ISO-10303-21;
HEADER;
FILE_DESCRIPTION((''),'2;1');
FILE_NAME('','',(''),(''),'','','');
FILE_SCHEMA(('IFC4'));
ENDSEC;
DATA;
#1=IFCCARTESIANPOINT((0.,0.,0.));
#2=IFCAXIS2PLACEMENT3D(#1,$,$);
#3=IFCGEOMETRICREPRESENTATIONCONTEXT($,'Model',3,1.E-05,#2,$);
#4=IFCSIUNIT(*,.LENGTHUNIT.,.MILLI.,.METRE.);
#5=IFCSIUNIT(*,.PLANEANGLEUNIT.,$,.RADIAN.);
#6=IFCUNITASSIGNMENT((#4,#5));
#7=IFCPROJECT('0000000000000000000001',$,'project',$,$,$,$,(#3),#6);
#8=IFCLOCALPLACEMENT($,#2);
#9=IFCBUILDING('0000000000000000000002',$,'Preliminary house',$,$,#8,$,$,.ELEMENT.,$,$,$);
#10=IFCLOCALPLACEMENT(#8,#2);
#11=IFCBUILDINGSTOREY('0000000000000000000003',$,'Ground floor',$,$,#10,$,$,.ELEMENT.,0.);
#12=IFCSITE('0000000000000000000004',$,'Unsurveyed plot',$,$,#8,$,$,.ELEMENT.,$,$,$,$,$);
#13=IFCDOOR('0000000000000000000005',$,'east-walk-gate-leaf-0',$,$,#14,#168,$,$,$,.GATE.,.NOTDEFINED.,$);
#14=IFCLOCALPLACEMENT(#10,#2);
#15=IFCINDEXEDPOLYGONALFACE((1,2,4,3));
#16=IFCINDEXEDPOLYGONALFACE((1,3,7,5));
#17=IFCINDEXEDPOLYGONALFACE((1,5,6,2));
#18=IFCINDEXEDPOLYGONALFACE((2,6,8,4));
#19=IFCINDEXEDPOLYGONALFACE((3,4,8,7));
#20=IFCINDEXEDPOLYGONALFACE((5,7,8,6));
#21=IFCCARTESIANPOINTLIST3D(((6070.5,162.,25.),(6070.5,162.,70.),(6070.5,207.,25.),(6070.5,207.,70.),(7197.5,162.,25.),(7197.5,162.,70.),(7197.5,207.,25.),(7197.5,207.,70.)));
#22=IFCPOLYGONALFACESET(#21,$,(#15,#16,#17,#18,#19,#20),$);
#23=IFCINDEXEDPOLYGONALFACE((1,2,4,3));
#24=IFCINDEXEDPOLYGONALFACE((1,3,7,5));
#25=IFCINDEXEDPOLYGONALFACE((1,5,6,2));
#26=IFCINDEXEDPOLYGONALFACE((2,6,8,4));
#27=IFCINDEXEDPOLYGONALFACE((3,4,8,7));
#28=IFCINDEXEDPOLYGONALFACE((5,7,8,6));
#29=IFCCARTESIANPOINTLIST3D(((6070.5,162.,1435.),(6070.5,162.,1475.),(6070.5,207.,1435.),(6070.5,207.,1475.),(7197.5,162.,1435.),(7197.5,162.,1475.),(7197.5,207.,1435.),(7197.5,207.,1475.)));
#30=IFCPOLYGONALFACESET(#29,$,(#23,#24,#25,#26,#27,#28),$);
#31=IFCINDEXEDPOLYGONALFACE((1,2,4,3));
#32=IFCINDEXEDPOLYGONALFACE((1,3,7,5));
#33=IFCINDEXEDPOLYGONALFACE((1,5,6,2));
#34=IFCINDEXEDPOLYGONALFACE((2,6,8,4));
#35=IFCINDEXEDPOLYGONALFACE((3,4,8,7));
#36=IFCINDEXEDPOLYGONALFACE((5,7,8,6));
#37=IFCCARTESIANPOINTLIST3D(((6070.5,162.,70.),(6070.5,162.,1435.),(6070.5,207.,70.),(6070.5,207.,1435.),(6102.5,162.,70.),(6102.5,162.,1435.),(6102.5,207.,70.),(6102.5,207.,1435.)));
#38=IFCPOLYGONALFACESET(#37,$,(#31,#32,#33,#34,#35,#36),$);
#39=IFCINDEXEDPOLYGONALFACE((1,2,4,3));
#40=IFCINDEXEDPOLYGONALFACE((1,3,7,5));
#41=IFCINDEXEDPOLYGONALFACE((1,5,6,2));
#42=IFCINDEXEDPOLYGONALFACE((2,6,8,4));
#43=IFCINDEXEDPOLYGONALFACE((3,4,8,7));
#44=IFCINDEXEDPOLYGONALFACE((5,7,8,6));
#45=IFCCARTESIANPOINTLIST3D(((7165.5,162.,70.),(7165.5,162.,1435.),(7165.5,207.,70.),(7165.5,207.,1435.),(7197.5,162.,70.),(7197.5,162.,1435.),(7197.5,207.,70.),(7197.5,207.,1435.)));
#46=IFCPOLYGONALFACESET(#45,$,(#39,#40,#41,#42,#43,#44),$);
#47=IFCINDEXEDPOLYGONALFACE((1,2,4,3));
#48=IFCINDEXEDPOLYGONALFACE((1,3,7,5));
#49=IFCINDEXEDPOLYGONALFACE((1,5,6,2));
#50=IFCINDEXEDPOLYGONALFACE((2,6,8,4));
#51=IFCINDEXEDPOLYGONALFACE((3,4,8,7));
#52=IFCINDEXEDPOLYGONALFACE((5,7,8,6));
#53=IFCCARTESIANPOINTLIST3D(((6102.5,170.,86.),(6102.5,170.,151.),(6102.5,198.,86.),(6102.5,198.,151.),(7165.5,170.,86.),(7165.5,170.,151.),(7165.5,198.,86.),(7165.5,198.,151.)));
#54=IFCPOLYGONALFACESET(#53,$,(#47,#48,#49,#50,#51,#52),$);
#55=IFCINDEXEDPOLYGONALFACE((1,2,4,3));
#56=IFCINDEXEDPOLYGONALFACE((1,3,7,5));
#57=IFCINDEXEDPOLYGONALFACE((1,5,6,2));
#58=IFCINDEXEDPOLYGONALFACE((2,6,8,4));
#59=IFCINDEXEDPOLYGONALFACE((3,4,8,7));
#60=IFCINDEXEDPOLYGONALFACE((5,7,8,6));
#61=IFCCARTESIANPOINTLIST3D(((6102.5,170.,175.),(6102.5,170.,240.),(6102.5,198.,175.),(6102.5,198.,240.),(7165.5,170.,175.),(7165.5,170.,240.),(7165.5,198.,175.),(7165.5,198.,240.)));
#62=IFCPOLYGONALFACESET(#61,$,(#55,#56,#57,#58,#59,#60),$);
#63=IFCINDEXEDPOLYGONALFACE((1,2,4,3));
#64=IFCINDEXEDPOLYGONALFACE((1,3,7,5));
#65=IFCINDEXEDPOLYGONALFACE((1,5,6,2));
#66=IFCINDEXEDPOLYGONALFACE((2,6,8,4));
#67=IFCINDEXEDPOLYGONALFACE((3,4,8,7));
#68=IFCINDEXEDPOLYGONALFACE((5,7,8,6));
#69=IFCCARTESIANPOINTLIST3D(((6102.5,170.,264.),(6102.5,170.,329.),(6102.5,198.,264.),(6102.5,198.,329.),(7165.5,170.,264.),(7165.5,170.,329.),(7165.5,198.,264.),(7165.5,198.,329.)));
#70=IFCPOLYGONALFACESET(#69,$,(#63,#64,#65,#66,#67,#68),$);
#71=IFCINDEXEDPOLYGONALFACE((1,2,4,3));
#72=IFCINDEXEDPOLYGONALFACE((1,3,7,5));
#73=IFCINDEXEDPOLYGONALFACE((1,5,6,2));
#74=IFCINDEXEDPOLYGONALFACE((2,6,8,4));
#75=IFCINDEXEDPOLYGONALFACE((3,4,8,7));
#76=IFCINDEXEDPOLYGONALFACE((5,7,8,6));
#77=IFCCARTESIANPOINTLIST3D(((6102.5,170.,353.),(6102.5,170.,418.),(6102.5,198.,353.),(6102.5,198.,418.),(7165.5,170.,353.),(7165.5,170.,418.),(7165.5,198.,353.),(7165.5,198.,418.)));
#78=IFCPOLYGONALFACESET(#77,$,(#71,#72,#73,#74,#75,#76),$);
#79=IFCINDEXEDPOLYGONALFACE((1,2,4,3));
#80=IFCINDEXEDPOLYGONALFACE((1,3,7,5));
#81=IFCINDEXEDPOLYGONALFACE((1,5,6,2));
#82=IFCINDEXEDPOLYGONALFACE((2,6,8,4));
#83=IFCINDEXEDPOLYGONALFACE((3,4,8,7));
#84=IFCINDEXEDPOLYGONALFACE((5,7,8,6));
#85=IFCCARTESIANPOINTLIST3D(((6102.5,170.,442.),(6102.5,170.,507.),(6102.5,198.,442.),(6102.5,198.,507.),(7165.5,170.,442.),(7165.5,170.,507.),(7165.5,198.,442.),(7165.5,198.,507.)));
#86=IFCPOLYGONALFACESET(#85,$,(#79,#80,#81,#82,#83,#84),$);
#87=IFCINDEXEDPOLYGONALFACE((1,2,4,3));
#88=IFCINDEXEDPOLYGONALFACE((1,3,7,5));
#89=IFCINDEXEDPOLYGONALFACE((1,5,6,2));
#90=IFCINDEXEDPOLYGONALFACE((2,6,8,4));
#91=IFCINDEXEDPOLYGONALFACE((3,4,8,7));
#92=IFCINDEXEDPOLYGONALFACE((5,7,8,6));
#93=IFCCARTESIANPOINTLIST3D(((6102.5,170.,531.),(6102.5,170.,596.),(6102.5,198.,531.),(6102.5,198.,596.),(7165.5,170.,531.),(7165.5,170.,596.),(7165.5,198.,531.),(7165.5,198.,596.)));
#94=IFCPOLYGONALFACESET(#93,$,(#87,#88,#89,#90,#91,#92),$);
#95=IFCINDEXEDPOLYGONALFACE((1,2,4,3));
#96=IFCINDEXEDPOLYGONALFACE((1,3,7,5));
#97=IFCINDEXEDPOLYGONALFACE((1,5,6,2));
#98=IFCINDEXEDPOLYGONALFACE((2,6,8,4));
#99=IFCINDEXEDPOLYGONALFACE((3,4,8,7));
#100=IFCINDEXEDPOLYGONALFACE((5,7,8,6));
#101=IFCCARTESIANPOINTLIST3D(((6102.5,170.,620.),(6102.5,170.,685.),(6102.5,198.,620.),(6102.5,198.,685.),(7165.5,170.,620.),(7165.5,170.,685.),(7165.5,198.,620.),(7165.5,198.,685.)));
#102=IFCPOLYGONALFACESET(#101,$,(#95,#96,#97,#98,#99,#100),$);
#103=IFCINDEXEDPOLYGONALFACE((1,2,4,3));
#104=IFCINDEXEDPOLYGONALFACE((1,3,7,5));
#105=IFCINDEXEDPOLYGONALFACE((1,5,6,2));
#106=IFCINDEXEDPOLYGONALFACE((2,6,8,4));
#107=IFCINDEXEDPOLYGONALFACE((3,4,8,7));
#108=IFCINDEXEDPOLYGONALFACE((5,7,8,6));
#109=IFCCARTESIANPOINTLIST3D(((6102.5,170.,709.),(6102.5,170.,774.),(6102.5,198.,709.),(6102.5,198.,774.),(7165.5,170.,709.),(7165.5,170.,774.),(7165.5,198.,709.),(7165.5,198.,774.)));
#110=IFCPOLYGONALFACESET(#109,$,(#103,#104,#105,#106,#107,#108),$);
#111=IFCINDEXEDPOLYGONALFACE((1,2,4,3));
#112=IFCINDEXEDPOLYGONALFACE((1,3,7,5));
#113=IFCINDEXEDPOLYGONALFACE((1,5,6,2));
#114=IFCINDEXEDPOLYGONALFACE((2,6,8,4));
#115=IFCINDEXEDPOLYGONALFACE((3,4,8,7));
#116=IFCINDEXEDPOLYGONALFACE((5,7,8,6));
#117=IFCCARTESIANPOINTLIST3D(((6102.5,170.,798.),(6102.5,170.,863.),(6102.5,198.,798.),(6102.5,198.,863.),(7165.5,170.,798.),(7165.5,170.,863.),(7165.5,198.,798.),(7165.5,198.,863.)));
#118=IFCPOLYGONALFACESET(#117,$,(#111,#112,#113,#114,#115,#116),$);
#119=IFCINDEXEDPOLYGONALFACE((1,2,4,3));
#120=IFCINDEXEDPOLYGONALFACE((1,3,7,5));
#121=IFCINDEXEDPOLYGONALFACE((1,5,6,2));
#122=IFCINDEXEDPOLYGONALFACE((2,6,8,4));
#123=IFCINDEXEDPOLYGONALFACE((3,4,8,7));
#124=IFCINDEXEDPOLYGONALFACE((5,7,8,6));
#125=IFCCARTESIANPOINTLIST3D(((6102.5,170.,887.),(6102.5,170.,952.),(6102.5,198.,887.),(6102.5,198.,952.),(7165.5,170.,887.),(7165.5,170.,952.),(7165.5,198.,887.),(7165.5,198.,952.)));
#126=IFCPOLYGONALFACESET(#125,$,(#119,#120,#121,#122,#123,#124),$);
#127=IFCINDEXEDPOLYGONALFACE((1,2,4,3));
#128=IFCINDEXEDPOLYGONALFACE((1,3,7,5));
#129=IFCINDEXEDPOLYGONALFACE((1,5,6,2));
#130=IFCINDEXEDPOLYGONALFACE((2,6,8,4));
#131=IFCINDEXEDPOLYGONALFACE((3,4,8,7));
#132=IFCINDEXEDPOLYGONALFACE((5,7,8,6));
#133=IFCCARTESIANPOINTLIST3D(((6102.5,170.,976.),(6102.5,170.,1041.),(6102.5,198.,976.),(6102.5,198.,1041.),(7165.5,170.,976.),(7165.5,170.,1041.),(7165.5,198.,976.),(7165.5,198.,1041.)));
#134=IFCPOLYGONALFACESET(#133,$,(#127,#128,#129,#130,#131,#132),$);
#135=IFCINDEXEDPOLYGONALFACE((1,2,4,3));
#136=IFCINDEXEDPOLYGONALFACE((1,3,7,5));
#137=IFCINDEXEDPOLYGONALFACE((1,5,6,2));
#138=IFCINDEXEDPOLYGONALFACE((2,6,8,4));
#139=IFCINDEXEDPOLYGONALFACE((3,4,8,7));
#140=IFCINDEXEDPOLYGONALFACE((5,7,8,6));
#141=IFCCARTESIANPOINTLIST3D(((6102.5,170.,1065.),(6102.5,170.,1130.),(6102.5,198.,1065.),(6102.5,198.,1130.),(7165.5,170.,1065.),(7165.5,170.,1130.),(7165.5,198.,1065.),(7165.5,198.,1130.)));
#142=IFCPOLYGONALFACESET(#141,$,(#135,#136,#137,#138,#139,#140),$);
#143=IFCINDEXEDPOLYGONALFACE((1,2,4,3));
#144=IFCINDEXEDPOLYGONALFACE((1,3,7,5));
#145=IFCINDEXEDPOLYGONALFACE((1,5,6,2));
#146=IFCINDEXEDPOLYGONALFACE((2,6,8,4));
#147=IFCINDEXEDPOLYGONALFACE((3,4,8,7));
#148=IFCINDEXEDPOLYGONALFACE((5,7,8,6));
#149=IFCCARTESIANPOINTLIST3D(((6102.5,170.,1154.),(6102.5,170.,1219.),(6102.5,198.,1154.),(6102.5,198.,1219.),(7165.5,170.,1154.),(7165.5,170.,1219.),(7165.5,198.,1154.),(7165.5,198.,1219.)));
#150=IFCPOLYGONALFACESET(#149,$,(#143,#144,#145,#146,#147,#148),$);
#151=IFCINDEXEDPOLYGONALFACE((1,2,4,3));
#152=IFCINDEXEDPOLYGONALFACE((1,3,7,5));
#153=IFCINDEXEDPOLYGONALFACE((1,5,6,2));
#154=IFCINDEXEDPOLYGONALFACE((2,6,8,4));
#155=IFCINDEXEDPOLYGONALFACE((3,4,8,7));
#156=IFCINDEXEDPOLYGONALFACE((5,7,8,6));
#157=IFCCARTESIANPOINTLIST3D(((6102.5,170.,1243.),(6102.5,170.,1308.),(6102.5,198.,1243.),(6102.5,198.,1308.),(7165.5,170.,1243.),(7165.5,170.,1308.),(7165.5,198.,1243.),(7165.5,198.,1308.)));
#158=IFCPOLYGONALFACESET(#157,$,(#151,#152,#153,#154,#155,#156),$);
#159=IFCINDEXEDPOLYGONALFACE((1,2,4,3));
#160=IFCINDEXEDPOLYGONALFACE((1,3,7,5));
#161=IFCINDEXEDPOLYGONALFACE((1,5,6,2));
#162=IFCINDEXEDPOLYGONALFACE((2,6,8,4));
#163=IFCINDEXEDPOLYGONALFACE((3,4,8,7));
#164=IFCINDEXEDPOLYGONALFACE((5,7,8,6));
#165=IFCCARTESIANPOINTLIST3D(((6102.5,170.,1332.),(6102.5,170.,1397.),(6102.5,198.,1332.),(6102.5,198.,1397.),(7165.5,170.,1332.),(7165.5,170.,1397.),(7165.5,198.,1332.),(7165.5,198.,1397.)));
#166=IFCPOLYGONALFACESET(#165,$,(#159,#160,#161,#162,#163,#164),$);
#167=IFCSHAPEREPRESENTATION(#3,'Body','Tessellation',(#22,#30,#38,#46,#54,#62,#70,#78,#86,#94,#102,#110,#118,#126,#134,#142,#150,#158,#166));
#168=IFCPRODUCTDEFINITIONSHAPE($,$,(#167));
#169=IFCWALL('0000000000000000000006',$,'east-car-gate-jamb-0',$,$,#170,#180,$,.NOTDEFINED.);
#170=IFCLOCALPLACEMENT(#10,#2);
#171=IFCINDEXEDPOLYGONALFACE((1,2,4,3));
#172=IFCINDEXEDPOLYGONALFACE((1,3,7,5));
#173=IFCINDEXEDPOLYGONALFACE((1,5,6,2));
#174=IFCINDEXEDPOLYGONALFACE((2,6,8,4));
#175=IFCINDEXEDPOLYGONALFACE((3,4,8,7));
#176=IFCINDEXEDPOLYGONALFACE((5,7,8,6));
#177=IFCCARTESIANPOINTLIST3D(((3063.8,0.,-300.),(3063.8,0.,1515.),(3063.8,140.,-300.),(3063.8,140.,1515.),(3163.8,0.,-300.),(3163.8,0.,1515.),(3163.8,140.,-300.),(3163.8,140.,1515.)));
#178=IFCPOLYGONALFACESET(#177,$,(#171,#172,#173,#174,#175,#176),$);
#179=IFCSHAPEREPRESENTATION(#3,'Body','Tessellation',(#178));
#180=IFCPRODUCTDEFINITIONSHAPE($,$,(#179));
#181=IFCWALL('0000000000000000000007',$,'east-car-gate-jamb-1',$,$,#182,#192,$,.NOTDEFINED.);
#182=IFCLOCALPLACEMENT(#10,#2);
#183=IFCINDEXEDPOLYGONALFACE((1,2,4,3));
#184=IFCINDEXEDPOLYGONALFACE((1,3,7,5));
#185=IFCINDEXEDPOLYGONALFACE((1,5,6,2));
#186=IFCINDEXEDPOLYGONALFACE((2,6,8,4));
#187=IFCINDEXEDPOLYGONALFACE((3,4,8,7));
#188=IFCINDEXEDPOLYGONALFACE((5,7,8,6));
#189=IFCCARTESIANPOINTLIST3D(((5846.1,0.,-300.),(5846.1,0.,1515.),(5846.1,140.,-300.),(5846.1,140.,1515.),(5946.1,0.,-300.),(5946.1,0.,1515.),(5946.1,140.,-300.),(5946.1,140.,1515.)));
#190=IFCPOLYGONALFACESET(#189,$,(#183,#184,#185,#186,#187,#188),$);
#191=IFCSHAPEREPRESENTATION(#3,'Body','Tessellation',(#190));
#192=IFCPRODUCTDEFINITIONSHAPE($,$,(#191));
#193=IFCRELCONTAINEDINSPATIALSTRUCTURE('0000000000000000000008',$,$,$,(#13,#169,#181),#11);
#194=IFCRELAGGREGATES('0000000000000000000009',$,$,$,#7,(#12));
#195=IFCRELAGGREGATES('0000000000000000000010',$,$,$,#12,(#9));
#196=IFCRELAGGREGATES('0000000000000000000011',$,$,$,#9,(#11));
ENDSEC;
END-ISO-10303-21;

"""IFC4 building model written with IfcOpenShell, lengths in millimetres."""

from ifc_helpers import new_model, si_unit, frame, origin, place, context, project, spatial, polyline, outline, extrude, element, save


model = new_model("IFC4")

# Units and contexts
model_context = context("Model", 3, precision=1e-05, world=origin())
ifc_project = project(units=[si_unit("LENGTHUNIT", "METRE", prefix="MILLI"), si_unit("PLANEANGLEUNIT", "RADIAN")], contexts=[model_context])

# Site, building, storey
placement_1 = place(None, origin())
site = spatial("IfcSite", under=ifc_project, at=placement_1, Name="Unsurveyed plot", CompositionType="ELEMENT")
building = spatial("IfcBuilding", under=site, at=placement_1, Name="Preliminary house", CompositionType="ELEMENT")
placement_2 = place(placement_1, origin())
storey = spatial("IfcBuildingStorey", under=building, at=placement_2, Name="Ground floor", CompositionType="ELEMENT", Elevation=0.0)

# Door
element("IfcDoor", 1, at=placement_2, inside=storey, Name="east-walk-gate-leaf-0", OperationType="NOTDEFINED", PredefinedType="GATE", context=model_context, shape_type="SweptSolid", body=[
    extrude(outline(polyline([(7197.5, 162.0), (7197.5, 207.0), (6070.5, 207.0), (6070.5, 162.0), (7197.5, 162.0)])), frame((0.0, 0.0, 25.0)), (0.0, 0.0, 1.0), 45.0),
    extrude(outline(polyline([(7197.5, 162.0), (7197.5, 207.0), (6070.5, 207.0), (6070.5, 162.0), (7197.5, 162.0)])), frame((0.0, 0.0, 1435.0)), (0.0, 0.0, 1.0), 40.0),
    extrude(outline(polyline([(6102.5, 162.0), (6102.5, 207.0), (6070.5, 207.0), (6070.5, 162.0), (6102.5, 162.0)])), frame((0.0, 0.0, 70.0)), (0.0, 0.0, 1.0), 1365.0),
    extrude(outline(polyline([(7197.5, 162.0), (7197.5, 207.0), (7165.5, 207.0), (7165.5, 162.0), (7197.5, 162.0)])), frame((0.0, 0.0, 70.0)), (0.0, 0.0, 1.0), 1365.0),
    extrude(outline(polyline([(7165.5, 170.0), (7165.5, 198.0), (6102.5, 198.0), (6102.5, 170.0), (7165.5, 170.0)])), frame((0.0, 0.0, 86.0)), (0.0, 0.0, 1.0), 65.0),
    extrude(outline(polyline([(7165.5, 170.0), (7165.5, 198.0), (6102.5, 198.0), (6102.5, 170.0), (7165.5, 170.0)])), frame((0.0, 0.0, 175.0)), (0.0, 0.0, 1.0), 65.0),
    extrude(outline(polyline([(7165.5, 170.0), (7165.5, 198.0), (6102.5, 198.0), (6102.5, 170.0), (7165.5, 170.0)])), frame((0.0, 0.0, 264.0)), (0.0, 0.0, 1.0), 65.0),
    extrude(outline(polyline([(7165.5, 170.0), (7165.5, 198.0), (6102.5, 198.0), (6102.5, 170.0), (7165.5, 170.0)])), frame((0.0, 0.0, 353.0)), (0.0, 0.0, 1.0), 65.0),
    extrude(outline(polyline([(7165.5, 170.0), (7165.5, 198.0), (6102.5, 198.0), (6102.5, 170.0), (7165.5, 170.0)])), frame((0.0, 0.0, 442.0)), (0.0, 0.0, 1.0), 65.0),
    extrude(outline(polyline([(7165.5, 170.0), (7165.5, 198.0), (6102.5, 198.0), (6102.5, 170.0), (7165.5, 170.0)])), frame((0.0, 0.0, 531.0)), (0.0, 0.0, 1.0), 65.0),
    extrude(outline(polyline([(7165.5, 170.0), (7165.5, 198.0), (6102.5, 198.0), (6102.5, 170.0), (7165.5, 170.0)])), frame((0.0, 0.0, 620.0)), (0.0, 0.0, 1.0), 65.0),
    extrude(outline(polyline([(7165.5, 170.0), (7165.5, 198.0), (6102.5, 198.0), (6102.5, 170.0), (7165.5, 170.0)])), frame((0.0, 0.0, 709.0)), (0.0, 0.0, 1.0), 65.0),
    extrude(outline(polyline([(7165.5, 170.0), (7165.5, 198.0), (6102.5, 198.0), (6102.5, 170.0), (7165.5, 170.0)])), frame((0.0, 0.0, 798.0)), (0.0, 0.0, 1.0), 65.0),
    extrude(outline(polyline([(7165.5, 170.0), (7165.5, 198.0), (6102.5, 198.0), (6102.5, 170.0), (7165.5, 170.0)])), frame((0.0, 0.0, 887.0)), (0.0, 0.0, 1.0), 65.0),
    extrude(outline(polyline([(7165.5, 170.0), (7165.5, 198.0), (6102.5, 198.0), (6102.5, 170.0), (7165.5, 170.0)])), frame((0.0, 0.0, 976.0)), (0.0, 0.0, 1.0), 65.0),
    extrude(outline(polyline([(7165.5, 170.0), (7165.5, 198.0), (6102.5, 198.0), (6102.5, 170.0), (7165.5, 170.0)])), frame((0.0, 0.0, 1065.0)), (0.0, 0.0, 1.0), 65.0),
    extrude(outline(polyline([(7165.5, 170.0), (7165.5, 198.0), (6102.5, 198.0), (6102.5, 170.0), (7165.5, 170.0)])), frame((0.0, 0.0, 1154.0)), (0.0, 0.0, 1.0), 65.0),
    extrude(outline(polyline([(7165.5, 170.0), (7165.5, 198.0), (6102.5, 198.0), (6102.5, 170.0), (7165.5, 170.0)])), frame((0.0, 0.0, 1243.0)), (0.0, 0.0, 1.0), 65.0),
    extrude(outline(polyline([(7165.5, 170.0), (7165.5, 198.0), (6102.5, 198.0), (6102.5, 170.0), (7165.5, 170.0)])), frame((0.0, 0.0, 1332.0)), (0.0, 0.0, 1.0), 65.0),
])

# Walls
element("IfcWall", 2, at=placement_2, inside=storey, Name="east-car-gate-jamb-0", PredefinedType="NOTDEFINED", context=model_context, shape_type="SweptSolid", body=[
    extrude(outline(polyline([(3163.8, 0.0), (3163.8, 140.0), (3063.8, 140.0), (3063.8, 0.0), (3163.8, 0.0)])), frame((0.0, 0.0, -300.0)), (0.0, 0.0, 1.0), 1815.0),
])
element("IfcWall", 3, at=placement_2, inside=storey, Name="east-car-gate-jamb-1", PredefinedType="NOTDEFINED", context=model_context, shape_type="SweptSolid", body=[
    extrude(outline(polyline([(5946.1, 0.0), (5946.1, 140.0), (5846.1, 140.0), (5846.1, 0.0), (5946.1, 0.0)])), frame((0.0, 0.0, -300.0)), (0.0, 0.0, 1.0), 1815.0),
])

save(model, "model.ifc")
